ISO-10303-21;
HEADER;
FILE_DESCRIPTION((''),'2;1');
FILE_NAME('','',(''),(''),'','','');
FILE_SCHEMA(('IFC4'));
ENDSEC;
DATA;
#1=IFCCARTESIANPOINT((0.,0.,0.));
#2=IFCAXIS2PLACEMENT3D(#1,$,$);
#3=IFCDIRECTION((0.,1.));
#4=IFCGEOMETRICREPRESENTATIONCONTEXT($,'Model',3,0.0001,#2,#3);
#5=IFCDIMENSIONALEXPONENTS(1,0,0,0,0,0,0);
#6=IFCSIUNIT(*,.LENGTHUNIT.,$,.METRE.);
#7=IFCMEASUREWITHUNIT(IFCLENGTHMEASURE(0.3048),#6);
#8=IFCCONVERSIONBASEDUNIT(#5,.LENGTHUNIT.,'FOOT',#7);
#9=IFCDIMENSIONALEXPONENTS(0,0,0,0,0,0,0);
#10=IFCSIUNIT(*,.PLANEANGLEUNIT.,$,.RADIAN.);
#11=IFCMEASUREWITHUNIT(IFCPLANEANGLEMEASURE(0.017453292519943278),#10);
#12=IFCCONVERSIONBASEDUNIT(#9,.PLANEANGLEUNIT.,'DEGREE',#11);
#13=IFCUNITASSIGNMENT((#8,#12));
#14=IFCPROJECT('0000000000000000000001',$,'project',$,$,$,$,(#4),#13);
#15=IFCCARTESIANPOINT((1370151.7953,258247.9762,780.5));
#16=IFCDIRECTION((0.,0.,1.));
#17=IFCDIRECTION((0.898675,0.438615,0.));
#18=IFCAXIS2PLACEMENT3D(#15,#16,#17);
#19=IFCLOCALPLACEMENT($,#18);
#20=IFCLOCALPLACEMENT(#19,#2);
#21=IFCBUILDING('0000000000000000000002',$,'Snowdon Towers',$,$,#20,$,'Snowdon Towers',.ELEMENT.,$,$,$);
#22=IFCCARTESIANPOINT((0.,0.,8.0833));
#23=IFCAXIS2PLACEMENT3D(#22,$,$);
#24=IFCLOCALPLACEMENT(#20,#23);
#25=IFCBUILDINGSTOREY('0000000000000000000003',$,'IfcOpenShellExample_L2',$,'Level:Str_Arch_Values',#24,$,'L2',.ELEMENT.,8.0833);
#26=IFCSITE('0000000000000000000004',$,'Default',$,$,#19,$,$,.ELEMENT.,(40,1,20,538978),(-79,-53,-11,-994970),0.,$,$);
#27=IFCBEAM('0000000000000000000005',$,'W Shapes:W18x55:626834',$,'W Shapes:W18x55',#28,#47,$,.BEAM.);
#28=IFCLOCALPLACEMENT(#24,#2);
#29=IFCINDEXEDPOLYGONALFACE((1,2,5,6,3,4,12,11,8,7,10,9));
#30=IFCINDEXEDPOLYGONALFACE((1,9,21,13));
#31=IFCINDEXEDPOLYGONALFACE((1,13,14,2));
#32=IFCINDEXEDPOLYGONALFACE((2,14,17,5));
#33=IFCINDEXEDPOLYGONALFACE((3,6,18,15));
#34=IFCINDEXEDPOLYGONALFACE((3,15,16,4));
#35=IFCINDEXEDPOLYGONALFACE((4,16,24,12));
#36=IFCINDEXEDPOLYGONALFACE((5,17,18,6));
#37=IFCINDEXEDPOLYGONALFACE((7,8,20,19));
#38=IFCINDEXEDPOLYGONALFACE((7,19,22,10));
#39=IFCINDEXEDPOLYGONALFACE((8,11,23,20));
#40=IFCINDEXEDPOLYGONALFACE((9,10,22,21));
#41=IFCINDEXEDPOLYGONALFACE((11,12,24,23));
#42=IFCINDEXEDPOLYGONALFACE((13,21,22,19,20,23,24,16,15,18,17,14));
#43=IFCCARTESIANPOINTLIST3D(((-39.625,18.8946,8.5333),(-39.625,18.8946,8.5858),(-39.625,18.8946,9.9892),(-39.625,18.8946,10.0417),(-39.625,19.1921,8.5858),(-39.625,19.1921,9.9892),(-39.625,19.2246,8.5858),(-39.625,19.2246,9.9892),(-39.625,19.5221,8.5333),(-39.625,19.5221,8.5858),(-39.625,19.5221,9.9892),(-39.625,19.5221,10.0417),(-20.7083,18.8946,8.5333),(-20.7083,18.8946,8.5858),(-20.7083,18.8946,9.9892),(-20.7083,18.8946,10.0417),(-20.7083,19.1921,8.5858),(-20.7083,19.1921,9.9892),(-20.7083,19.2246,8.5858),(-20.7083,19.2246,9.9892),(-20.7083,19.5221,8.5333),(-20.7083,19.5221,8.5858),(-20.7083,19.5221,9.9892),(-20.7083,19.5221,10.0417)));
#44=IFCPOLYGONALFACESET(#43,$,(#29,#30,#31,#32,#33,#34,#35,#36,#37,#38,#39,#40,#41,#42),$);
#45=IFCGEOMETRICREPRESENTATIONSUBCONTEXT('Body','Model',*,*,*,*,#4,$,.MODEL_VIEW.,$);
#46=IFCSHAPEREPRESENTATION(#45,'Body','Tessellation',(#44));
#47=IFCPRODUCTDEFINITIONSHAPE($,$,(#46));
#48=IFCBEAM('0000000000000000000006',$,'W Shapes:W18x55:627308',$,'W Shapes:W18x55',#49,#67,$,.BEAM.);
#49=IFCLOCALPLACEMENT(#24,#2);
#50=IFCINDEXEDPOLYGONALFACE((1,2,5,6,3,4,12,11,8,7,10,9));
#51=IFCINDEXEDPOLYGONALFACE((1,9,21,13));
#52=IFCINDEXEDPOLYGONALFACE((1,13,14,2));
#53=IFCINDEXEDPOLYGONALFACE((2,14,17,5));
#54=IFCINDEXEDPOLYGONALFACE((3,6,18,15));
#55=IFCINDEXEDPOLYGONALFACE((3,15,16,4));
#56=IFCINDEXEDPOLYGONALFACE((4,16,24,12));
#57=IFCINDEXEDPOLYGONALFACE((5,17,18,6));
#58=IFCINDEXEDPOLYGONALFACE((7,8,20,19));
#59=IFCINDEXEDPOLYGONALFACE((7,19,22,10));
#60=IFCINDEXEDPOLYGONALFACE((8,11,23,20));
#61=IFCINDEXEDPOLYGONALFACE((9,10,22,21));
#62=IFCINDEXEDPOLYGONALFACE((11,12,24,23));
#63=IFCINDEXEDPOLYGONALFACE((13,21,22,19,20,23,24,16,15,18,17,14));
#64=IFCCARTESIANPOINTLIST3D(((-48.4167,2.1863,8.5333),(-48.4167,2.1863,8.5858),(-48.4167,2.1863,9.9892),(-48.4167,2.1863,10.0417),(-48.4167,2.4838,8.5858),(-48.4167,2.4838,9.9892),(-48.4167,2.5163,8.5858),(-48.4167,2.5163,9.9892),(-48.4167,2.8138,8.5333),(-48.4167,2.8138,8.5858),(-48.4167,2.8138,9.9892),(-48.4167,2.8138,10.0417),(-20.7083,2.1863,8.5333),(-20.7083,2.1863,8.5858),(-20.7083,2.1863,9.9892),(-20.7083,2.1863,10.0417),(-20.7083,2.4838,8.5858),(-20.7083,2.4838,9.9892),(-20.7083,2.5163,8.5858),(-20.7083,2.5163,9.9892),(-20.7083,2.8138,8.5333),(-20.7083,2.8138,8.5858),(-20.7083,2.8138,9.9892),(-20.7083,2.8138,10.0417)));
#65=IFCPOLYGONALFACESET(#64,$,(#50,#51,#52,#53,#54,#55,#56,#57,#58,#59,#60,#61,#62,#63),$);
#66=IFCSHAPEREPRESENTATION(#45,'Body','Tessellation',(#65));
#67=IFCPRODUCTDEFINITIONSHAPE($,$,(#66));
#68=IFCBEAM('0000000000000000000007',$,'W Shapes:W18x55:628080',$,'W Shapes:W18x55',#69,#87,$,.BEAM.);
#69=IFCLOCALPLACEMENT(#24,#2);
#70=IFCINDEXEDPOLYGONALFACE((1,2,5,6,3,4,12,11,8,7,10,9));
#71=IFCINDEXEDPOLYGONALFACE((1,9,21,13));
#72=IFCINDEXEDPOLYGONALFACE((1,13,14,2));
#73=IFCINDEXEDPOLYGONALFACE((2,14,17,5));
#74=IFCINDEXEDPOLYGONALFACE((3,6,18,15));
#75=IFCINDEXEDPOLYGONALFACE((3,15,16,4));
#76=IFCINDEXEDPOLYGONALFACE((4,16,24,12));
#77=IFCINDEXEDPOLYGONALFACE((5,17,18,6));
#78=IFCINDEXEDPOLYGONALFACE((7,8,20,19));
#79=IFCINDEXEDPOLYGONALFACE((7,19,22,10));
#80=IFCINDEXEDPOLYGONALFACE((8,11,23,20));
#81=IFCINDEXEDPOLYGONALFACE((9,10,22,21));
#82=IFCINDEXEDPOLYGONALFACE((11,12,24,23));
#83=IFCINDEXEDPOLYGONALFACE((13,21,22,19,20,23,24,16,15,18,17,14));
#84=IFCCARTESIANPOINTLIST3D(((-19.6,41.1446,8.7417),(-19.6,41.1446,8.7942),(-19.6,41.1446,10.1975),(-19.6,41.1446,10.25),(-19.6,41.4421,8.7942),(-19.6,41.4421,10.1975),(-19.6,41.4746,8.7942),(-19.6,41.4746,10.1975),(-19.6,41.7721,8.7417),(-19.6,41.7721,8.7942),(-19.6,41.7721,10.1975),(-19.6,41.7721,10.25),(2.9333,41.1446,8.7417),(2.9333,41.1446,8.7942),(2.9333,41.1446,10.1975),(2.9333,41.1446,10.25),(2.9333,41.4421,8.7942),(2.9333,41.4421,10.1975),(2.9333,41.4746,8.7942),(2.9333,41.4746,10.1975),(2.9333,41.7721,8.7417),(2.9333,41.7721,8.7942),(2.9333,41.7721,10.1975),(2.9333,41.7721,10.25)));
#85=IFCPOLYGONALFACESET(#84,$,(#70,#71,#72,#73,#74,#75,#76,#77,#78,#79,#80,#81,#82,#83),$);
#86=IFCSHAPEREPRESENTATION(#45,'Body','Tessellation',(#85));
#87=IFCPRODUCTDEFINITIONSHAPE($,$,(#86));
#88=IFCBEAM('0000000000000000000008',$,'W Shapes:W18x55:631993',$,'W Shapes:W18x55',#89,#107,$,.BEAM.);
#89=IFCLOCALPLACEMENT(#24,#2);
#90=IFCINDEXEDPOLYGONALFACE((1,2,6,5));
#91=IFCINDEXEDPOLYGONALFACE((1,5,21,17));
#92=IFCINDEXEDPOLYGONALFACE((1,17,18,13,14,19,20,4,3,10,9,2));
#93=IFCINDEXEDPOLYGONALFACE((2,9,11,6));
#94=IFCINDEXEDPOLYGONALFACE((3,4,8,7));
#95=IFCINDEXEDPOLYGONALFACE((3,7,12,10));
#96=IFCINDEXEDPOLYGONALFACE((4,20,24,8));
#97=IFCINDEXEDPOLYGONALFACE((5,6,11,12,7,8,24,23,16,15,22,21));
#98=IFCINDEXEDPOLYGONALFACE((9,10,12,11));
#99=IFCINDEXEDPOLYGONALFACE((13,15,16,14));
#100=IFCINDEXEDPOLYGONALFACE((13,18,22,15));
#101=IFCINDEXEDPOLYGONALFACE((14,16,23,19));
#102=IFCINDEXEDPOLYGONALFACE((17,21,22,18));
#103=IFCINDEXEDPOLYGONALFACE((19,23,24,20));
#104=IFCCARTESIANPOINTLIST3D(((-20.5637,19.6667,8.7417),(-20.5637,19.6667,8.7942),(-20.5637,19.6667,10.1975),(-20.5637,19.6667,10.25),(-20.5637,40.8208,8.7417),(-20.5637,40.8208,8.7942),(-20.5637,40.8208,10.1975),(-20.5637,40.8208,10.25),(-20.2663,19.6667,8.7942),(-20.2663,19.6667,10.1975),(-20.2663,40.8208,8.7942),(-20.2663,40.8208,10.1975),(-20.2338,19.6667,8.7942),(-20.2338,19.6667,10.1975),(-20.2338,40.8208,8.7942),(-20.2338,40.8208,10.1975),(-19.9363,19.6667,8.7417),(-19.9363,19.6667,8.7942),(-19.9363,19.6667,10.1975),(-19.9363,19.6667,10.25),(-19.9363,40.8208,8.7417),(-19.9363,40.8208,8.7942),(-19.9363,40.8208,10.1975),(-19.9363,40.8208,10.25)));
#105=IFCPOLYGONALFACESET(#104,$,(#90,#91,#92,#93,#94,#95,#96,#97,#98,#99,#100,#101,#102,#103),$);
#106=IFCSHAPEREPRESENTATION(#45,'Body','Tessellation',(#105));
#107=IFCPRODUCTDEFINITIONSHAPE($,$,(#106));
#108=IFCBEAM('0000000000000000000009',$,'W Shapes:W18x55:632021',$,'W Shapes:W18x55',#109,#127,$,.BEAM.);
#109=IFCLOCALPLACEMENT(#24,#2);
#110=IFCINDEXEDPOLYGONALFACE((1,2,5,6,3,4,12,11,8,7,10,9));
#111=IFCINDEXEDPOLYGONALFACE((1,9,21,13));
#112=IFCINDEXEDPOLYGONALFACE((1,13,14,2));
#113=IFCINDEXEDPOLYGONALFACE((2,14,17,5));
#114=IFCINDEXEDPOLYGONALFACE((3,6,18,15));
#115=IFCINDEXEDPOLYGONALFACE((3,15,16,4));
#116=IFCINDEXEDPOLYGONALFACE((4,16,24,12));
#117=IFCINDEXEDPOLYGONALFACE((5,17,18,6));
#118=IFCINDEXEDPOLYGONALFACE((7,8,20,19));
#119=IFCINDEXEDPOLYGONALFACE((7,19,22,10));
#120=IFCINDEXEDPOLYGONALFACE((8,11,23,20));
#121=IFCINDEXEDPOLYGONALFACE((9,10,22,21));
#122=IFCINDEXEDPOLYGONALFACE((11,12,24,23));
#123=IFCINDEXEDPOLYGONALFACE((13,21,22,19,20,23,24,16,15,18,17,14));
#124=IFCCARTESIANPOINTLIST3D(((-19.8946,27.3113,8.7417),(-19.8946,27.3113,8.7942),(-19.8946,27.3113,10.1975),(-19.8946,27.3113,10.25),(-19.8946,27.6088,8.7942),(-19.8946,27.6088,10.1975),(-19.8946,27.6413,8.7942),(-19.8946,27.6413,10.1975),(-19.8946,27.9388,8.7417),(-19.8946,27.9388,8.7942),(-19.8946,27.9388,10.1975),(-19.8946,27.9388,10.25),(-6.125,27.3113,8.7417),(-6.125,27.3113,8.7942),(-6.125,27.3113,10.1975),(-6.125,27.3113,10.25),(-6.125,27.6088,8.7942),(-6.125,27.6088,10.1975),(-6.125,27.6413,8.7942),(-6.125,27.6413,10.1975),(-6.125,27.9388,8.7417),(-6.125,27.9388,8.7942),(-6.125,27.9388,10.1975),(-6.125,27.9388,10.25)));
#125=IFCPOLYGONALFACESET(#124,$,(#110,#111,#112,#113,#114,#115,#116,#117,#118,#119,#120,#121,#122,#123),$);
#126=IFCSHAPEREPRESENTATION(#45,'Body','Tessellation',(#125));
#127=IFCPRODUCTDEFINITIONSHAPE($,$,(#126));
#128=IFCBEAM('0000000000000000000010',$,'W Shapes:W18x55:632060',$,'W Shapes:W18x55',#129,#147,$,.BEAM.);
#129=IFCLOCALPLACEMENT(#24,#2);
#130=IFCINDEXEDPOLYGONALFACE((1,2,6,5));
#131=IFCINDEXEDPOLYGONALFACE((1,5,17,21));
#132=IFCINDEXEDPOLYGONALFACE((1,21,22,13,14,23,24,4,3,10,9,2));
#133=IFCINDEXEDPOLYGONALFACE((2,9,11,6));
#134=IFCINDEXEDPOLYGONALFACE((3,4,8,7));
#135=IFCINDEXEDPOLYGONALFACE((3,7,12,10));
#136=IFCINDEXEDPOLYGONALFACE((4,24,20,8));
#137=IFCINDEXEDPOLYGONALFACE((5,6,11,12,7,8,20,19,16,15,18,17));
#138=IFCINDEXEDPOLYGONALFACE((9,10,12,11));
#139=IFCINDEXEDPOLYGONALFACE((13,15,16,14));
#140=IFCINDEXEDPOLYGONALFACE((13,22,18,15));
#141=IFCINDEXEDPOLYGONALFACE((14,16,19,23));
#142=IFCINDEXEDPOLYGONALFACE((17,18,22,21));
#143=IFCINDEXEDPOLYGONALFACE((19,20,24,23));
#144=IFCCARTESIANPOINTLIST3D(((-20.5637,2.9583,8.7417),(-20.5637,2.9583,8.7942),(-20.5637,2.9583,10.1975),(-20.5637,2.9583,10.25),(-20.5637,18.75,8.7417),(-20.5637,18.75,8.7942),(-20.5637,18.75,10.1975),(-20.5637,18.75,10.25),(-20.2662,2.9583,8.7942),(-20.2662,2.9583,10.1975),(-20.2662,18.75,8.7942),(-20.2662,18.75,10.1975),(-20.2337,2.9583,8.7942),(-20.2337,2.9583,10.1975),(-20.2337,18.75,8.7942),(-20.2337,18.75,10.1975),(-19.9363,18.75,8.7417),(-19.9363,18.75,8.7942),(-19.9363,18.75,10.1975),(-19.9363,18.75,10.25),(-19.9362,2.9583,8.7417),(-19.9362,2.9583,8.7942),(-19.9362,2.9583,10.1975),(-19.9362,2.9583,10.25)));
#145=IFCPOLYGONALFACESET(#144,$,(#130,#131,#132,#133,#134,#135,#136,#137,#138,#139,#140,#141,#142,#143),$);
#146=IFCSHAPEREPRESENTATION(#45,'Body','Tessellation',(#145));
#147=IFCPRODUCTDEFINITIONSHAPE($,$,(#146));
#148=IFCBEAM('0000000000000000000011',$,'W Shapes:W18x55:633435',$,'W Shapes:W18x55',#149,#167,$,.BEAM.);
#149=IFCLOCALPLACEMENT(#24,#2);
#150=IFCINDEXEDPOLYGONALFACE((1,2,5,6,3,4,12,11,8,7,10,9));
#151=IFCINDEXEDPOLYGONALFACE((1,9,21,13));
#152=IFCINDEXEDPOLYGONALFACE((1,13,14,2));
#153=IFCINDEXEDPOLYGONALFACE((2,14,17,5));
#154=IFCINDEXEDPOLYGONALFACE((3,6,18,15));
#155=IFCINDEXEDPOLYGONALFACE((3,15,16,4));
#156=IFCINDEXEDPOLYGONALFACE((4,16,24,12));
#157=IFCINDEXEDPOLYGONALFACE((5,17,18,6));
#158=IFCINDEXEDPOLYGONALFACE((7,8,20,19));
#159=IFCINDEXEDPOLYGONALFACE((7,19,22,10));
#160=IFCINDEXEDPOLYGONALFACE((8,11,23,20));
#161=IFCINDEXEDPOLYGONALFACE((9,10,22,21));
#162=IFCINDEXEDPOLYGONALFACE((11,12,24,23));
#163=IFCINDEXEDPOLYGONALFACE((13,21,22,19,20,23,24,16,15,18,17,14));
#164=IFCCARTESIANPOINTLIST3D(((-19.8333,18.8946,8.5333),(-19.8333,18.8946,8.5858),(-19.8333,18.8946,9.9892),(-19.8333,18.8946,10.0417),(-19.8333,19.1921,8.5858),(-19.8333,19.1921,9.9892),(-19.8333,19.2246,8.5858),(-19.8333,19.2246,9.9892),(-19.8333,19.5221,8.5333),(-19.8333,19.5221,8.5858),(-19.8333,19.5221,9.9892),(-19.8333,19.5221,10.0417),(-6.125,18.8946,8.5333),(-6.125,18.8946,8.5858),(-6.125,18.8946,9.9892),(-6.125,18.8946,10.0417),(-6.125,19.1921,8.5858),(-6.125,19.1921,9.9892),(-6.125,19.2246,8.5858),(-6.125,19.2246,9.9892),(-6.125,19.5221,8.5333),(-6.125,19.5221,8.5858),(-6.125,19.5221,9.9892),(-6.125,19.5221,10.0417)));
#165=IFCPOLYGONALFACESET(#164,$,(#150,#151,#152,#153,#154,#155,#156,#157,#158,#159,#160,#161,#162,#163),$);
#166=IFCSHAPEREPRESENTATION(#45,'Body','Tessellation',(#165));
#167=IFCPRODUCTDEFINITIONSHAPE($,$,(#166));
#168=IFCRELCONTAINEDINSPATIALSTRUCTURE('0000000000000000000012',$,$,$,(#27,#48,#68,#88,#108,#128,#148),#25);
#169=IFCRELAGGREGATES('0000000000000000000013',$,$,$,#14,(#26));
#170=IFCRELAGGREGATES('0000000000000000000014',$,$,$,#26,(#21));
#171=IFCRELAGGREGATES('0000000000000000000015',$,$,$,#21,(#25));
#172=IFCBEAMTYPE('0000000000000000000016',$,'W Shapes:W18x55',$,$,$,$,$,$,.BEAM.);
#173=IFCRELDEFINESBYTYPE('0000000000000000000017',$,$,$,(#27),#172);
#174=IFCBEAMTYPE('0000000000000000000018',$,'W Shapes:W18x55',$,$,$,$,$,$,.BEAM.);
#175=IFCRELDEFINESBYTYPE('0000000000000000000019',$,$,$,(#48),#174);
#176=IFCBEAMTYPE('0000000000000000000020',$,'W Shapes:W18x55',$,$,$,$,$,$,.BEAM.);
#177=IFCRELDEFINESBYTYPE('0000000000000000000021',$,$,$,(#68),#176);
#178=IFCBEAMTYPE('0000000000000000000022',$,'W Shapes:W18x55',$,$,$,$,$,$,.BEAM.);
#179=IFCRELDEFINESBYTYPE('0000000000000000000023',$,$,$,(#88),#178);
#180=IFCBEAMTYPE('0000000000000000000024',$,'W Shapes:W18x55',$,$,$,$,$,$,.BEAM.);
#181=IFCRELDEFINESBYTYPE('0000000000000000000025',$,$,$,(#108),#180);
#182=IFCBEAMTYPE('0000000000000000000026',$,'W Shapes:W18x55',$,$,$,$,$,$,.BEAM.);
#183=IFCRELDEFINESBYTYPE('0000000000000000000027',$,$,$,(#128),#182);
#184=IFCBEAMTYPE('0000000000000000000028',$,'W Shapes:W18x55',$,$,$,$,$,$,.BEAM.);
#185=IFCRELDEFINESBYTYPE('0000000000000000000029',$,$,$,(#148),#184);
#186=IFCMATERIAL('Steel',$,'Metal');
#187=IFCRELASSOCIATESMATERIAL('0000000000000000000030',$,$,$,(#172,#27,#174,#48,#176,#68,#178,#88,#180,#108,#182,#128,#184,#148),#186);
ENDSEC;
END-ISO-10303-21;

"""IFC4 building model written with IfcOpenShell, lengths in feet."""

from ifc_helpers import new_model, entity, si_unit, converted_unit, direction, frame, origin, place, context, subcontext, project, spatial, indexed_curve, outline, extrude, source, transform, mapped, material, type_object, type_shapes, element, save


model = new_model("IFC4")

# Units and contexts
model_context = context("Model", 3, precision=0.0001, world=origin(), true_north=direction((0.0, 1.0)))
body_context = subcontext(model_context, "Body", "Model", "MODEL_VIEW")
ifc_project = project(units=[converted_unit("LENGTHUNIT", "FOOT", entity("IfcLengthMeasure", 0.3048), si_unit("LENGTHUNIT", "METRE"), dimensions=[1, 0, 0, 0, 0, 0, 0]), converted_unit("PLANEANGLEUNIT", "DEGREE", entity("IfcPlaneAngleMeasure", 0.017453292519943278), si_unit("PLANEANGLEUNIT", "RADIAN"), dimensions=[0, 0, 0, 0, 0, 0, 0])], contexts=[model_context])

# Site, building, storey
site_placement = place(None, frame((1370151.7953, 258247.9762, 780.5), z_axis=(0.0, 0.0, 1.0), x_axis=(0.898675, 0.438615, 0.0)))
site = spatial("IfcSite", under=ifc_project, at=site_placement, Name="Default", CompositionType="ELEMENT", RefLatitude=(40, 1, 20, 538978), RefLongitude=(-79, -53, -11, -994970), RefElevation=0.0)
building_placement = place(site_placement, origin())
building = spatial("IfcBuilding", under=site, at=building_placement, Name="Snowdon Towers", LongName="Snowdon Towers", CompositionType="ELEMENT")
storey_placement = place(building_placement, frame((0.0, 0.0, 8.0833)))
storey = spatial("IfcBuildingStorey", under=building, at=storey_placement, Name="IfcOpenShellExample_L2", ObjectType="Level:Str_Arch_Values", LongName="L2", CompositionType="ELEMENT", Elevation=8.0833)

# Shared definitions
ifc_material = material(Name="Steel", Category="Metal")

# Beams
beam_type_1 = type_object("IfcBeamType", Name="W Shapes:W18x55", PredefinedType="BEAM", material=ifc_material)
shared_shape_1 = source(origin(), body_context, "Body", "SweptSolid", [
    extrude(outline(indexed_curve([(-0.3138, -0.7017), (-0.3138, -0.7542), (0.3138, -0.7542), (0.3138, -0.7017), (0.0162, -0.7017), (0.0162, 0.7017), (0.3138, 0.7017), (0.3138, 0.7542), (-0.3137, 0.7542), (-0.3137, 0.7017), (-0.0163, 0.7017), (-0.0163, -0.7017), (-0.3138, -0.7017)], self_intersect=False)), frame((-9.5625, 0.0, 0.0), z_axis=(-1.0, 0.0, 0.0), x_axis=(0.0, -1.0, 0.0)), (0.0, 0.0, -1.0), 18.9167),
])
type_shapes(beam_type_1, [shared_shape_1])
beam_1_placement = place(storey_placement, frame((-30.0625, 19.2083, 9.2875)))
element("IfcBeam", 1, at=beam_1_placement, inside=storey, type_object=beam_type_1, material=ifc_material, Name="W Shapes:W18x55:626834", ObjectType="W Shapes:W18x55", PredefinedType="BEAM", context=body_context, shape_type="MappedRepresentation", body=[
    mapped(shared_shape_1, transform((0.0, 0.0, 0.0), scale=1.0)),
])
beam_type_2 = type_object("IfcBeamType", Name="W Shapes:W18x55", PredefinedType="BEAM", material=ifc_material)
shared_shape_2 = source(origin(), body_context, "Body", "SweptSolid", [
    extrude(outline(indexed_curve([(-0.3138, -0.7017), (-0.3138, -0.7542), (0.3138, -0.7542), (0.3138, -0.7017), (0.0162, -0.7017), (0.0162, 0.7017), (0.3138, 0.7017), (0.3138, 0.7542), (-0.3137, 0.7542), (-0.3137, 0.7017), (-0.0163, 0.7017), (-0.0163, -0.7017), (-0.3138, -0.7017)], self_intersect=False)), frame((-13.6667, 0.0, 0.0), z_axis=(-1.0, 0.0, 0.0), x_axis=(0.0, -1.0, 0.0)), (0.0, 0.0, -1.0), 27.7083),
])
type_shapes(beam_type_2, [shared_shape_2])
beam_2_placement = place(storey_placement, frame((-34.75, 2.5, 9.2875)))
element("IfcBeam", 2, at=beam_2_placement, inside=storey, type_object=beam_type_2, material=ifc_material, Name="W Shapes:W18x55:627308", ObjectType="W Shapes:W18x55", PredefinedType="BEAM", context=body_context, shape_type="MappedRepresentation", body=[
    mapped(shared_shape_2, transform((0.0, 0.0, 0.0), scale=1.0)),
])
beam_type_3 = type_object("IfcBeamType", Name="W Shapes:W18x55", PredefinedType="BEAM", material=ifc_material)
shared_shape_3 = source(origin(), body_context, "Body", "SweptSolid", [
    extrude(outline(indexed_curve([(-0.3138, -0.7017), (-0.3138, -0.7542), (0.3138, -0.7542), (0.3138, -0.7017), (0.0162, -0.7017), (0.0162, 0.7017), (0.3138, 0.7017), (0.3138, 0.7542), (-0.3137, 0.7542), (-0.3137, 0.7017), (-0.0163, 0.7017), (-0.0163, -0.7017), (-0.3138, -0.7017)], self_intersect=False)), frame((-11.35, 0.0, 0.0), z_axis=(-1.0, 0.0, 0.0), x_axis=(0.0, -1.0, 0.0)), (0.0, 0.0, -1.0), 22.5333),
])
type_shapes(beam_type_3, [shared_shape_3])
beam_3_placement = place(storey_placement, frame((-8.25, 41.4583, 9.4958)))
element("IfcBeam", 3, at=beam_3_placement, inside=storey, type_object=beam_type_3, material=ifc_material, Name="W Shapes:W18x55:628080", ObjectType="W Shapes:W18x55", PredefinedType="BEAM", context=body_context, shape_type="MappedRepresentation", body=[
    mapped(shared_shape_3, transform((0.0, 0.0, 0.0), scale=1.0)),
])

# Beams
beam_type_4 = type_object("IfcBeamType", Name="W Shapes:W18x55", PredefinedType="BEAM", material=ifc_material)
shared_shape_4 = source(origin(), body_context, "Body", "SweptSolid", [
    extrude(outline(indexed_curve([(-0.3138, -0.7017), (-0.3138, -0.7542), (0.3138, -0.7542), (0.3138, -0.7017), (0.0162, -0.7017), (0.0162, 0.7017), (0.3138, 0.7017), (0.3138, 0.7542), (-0.3137, 0.7542), (-0.3137, 0.7017), (-0.0163, 0.7017), (-0.0163, -0.7017), (-0.3138, -0.7017)], self_intersect=False)), frame((-10.4042, 0.0, 0.0), z_axis=(-1.0, 0.0, 0.0), x_axis=(0.0, -1.0, 0.0)), (0.0, 0.0, -1.0), 21.1542),
])
type_shapes(beam_type_4, [shared_shape_4])
beam_4_placement = place(storey_placement, frame((-20.25, 30.4167, 9.4958), z_axis=(0.0, 0.0, 1.0), x_axis=(0.0, -1.0, 0.0)))
element("IfcBeam", 4, at=beam_4_placement, inside=storey, type_object=beam_type_4, material=ifc_material, Name="W Shapes:W18x55:631993", ObjectType="W Shapes:W18x55", PredefinedType="BEAM", context=body_context, shape_type="MappedRepresentation", body=[
    mapped(shared_shape_4, transform((0.0, 0.0, 0.0), scale=1.0)),
])
beam_type_5 = type_object("IfcBeamType", Name="W Shapes:W18x55", PredefinedType="BEAM", material=ifc_material)
shared_shape_5 = source(origin(), body_context, "Body", "SweptSolid", [
    extrude(outline(indexed_curve([(-0.3138, -0.7017), (-0.3138, -0.7542), (0.3138, -0.7542), (0.3138, -0.7017), (0.0162, -0.7017), (0.0162, 0.7017), (0.3138, 0.7017), (0.3138, 0.7542), (-0.3137, 0.7542), (-0.3137, 0.7017), (-0.0163, 0.7017), (-0.0163, -0.7017), (-0.3138, -0.7017)], self_intersect=False)), frame((-6.8333, 0.0, 0.0), z_axis=(-1.0, 0.0, 0.0), x_axis=(0.0, -1.0, 0.0)), (0.0, 0.0, -1.0), 13.7696),
])
type_shapes(beam_type_5, [shared_shape_5])
beam_5_placement = place(storey_placement, frame((-12.9583, 27.625, 9.4958), z_axis=(0.0, 0.0, 1.0), x_axis=(-1.0, 0.0, 0.0)))
element("IfcBeam", 5, at=beam_5_placement, inside=storey, type_object=beam_type_5, material=ifc_material, Name="W Shapes:W18x55:632021", ObjectType="W Shapes:W18x55", PredefinedType="BEAM", context=body_context, shape_type="MappedRepresentation", body=[
    mapped(shared_shape_5, transform((0.0, 0.0, 0.0), scale=1.0)),
])
beam_type_6 = type_object("IfcBeamType", Name="W Shapes:W18x55", PredefinedType="BEAM", material=ifc_material)
shared_shape_6 = source(origin(), body_context, "Body", "SweptSolid", [
    extrude(outline(indexed_curve([(-0.3138, -0.7017), (-0.3138, -0.7542), (0.3138, -0.7542), (0.3138, -0.7017), (0.0162, -0.7017), (0.0162, 0.7017), (0.3138, 0.7017), (0.3138, 0.7542), (-0.3137, 0.7542), (-0.3137, 0.7017), (-0.0163, 0.7017), (-0.0163, -0.7017), (-0.3138, -0.7017)], self_intersect=False)), frame((-7.8958, 0.0, 0.0), z_axis=(-1.0, 0.0, 0.0), x_axis=(0.0, -1.0, 0.0)), (0.0, 0.0, -1.0), 15.7917),
])
type_shapes(beam_type_6, [shared_shape_6])
beam_6_placement = place(storey_placement, frame((-20.25, 10.8542, 9.4958), z_axis=(0.0, 0.0, 1.0), x_axis=(0.0, -1.0, 0.0)))
element("IfcBeam", 6, at=beam_6_placement, inside=storey, type_object=beam_type_6, material=ifc_material, Name="W Shapes:W18x55:632060", ObjectType="W Shapes:W18x55", PredefinedType="BEAM", context=body_context, shape_type="MappedRepresentation", body=[
    mapped(shared_shape_6, transform((0.0, 0.0, 0.0), scale=1.0)),
])
beam_type_7 = type_object("IfcBeamType", Name="W Shapes:W18x55", PredefinedType="BEAM", material=ifc_material)
shared_shape_7 = source(origin(), body_context, "Body", "SweptSolid", [
    extrude(outline(indexed_curve([(-0.3138, -0.7017), (-0.3138, -0.7542), (0.3138, -0.7542), (0.3138, -0.7017), (0.0162, -0.7017), (0.0162, 0.7017), (0.3138, 0.7017), (0.3138, 0.7542), (-0.3137, 0.7542), (-0.3137, 0.7017), (-0.0163, 0.7017), (-0.0163, -0.7017), (-0.3138, -0.7017)], self_intersect=False)), frame((-6.8333, 0.0, 0.0), z_axis=(-1.0, 0.0, 0.0), x_axis=(0.0, -1.0, 0.0)), (0.0, 0.0, -1.0), 13.7083),
])
type_shapes(beam_type_7, [shared_shape_7])
beam_7_placement = place(storey_placement, frame((-12.9583, 19.2083, 9.2875), z_axis=(0.0, 0.0, 1.0), x_axis=(-1.0, 0.0, 0.0)))
element("IfcBeam", 7, at=beam_7_placement, inside=storey, type_object=beam_type_7, material=ifc_material, Name="W Shapes:W18x55:633435", ObjectType="W Shapes:W18x55", PredefinedType="BEAM", context=body_context, shape_type="MappedRepresentation", body=[
    mapped(shared_shape_7, transform((0.0, 0.0, 0.0), scale=1.0)),
])

save(model, "model.ifc")
